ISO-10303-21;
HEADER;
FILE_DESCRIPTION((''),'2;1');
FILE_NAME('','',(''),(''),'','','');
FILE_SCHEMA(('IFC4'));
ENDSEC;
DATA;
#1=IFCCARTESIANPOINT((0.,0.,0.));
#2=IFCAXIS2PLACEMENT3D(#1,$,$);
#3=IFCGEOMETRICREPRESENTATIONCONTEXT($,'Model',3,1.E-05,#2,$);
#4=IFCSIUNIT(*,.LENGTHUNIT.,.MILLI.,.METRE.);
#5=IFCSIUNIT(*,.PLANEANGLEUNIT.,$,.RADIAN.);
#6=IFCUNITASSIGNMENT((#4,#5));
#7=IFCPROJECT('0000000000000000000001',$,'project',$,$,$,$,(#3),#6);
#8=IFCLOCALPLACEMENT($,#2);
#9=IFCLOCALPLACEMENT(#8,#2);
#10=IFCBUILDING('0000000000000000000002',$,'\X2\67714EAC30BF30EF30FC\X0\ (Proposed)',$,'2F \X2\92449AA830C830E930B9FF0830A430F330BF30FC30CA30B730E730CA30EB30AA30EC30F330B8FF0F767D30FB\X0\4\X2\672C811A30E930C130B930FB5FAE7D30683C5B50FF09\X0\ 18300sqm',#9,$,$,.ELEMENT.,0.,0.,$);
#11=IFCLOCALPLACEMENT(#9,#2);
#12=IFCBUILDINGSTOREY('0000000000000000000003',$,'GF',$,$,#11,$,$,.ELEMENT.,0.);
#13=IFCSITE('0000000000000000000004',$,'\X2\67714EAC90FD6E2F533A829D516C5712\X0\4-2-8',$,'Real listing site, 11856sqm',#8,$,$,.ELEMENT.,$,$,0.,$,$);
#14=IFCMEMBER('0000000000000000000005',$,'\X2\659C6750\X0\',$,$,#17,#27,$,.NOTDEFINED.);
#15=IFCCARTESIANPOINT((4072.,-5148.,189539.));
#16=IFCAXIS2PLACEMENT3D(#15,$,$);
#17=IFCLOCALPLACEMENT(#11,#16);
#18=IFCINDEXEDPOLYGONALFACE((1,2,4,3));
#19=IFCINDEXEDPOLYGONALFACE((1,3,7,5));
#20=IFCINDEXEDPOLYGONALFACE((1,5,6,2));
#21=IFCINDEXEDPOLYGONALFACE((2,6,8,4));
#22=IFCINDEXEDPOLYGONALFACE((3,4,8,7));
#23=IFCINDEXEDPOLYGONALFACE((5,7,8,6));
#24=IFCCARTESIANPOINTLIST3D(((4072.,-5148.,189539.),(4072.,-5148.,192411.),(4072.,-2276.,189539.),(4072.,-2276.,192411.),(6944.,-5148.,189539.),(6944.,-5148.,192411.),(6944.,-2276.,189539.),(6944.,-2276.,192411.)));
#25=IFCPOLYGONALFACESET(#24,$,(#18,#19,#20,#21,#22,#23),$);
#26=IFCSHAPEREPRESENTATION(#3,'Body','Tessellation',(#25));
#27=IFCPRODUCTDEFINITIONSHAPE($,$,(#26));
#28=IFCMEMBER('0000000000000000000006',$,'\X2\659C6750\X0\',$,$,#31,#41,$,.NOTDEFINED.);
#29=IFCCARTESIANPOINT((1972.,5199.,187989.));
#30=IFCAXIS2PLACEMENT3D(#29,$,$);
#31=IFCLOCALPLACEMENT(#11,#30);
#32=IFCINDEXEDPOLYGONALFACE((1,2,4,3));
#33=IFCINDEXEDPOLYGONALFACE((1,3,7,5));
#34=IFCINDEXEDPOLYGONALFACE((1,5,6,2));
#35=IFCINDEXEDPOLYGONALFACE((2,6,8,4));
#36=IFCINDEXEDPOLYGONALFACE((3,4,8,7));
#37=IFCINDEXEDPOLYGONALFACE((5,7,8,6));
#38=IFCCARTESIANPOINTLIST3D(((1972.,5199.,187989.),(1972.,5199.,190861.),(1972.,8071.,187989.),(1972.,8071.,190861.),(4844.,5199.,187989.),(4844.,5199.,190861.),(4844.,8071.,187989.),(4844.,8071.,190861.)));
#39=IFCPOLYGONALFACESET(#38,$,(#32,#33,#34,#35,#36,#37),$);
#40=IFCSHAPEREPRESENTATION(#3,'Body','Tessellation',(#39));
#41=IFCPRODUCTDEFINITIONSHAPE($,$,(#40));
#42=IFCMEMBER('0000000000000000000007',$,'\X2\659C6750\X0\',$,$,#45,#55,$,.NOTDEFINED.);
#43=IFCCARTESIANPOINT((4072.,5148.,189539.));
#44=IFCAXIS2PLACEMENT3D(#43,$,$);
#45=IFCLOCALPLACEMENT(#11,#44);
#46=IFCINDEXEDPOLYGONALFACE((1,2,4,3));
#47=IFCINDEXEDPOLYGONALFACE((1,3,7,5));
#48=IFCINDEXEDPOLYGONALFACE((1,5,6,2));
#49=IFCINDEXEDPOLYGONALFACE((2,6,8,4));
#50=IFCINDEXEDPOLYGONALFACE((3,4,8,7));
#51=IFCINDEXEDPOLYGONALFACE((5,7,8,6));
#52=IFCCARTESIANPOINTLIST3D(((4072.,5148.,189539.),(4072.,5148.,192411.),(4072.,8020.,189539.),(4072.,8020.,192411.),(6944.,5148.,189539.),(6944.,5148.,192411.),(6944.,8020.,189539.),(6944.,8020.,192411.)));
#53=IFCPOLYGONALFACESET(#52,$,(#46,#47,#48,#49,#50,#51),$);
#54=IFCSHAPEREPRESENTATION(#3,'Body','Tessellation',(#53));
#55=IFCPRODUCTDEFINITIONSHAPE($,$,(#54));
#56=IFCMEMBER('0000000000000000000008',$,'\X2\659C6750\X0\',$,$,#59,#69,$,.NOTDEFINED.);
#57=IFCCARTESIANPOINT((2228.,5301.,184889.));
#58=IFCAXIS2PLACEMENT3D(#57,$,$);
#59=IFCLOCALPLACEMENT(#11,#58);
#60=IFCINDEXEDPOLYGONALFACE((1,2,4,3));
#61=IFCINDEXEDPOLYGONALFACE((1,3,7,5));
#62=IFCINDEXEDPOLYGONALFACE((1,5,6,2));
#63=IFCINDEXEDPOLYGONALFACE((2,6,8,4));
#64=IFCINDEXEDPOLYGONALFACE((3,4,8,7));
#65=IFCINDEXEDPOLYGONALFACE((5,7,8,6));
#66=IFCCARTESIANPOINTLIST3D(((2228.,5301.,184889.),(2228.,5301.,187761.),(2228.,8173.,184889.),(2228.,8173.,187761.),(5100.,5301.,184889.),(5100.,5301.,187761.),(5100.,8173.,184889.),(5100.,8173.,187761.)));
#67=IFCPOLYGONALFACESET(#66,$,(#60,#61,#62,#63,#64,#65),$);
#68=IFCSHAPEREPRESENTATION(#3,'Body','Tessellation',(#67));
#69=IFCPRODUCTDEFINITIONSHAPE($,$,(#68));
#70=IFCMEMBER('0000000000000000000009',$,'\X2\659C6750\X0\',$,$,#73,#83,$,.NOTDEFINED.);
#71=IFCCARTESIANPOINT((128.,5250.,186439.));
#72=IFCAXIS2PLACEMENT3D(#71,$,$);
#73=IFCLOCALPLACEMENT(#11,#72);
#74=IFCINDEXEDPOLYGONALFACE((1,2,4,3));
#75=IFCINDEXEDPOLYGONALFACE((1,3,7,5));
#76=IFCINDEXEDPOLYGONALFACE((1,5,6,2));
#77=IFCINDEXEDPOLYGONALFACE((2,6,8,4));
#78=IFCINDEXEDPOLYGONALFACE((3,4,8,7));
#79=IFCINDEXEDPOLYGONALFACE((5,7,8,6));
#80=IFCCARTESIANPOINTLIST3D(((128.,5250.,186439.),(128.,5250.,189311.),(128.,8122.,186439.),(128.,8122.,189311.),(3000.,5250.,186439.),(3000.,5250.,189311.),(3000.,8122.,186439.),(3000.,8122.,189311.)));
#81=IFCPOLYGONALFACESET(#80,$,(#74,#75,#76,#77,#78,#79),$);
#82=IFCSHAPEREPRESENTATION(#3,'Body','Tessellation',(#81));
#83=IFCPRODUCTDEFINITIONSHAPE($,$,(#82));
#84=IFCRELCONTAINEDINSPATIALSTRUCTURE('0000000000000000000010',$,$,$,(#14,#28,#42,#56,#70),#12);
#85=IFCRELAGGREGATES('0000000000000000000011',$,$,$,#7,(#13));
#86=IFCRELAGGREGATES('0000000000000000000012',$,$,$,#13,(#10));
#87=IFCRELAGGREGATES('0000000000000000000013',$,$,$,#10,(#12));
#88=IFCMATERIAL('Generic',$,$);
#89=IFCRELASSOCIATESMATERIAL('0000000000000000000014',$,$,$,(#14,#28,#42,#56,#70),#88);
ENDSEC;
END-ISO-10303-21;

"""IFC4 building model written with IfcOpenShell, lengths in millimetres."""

from ifc_helpers import new_model, si_unit, frame, frame_2d, origin, place, context, project, spatial, rectangle, extrude, material, element, save


model = new_model("IFC4")

# Units and contexts
model_context = context("Model", 3, precision=1e-05, world=origin())
ifc_project = project(units=[si_unit("LENGTHUNIT", "METRE", prefix="MILLI"), si_unit("PLANEANGLEUNIT", "RADIAN")], contexts=[model_context])

# Site, building, storey
site_placement = place(None, origin())
site = spatial("IfcSite", under=ifc_project, at=site_placement, Name="東京都港区芝公園4-2-8", ObjectType="Real listing site, 11856sqm", CompositionType="ELEMENT", RefElevation=0.0)
building_placement = place(site_placement, origin())
building = spatial("IfcBuilding", under=site, at=building_placement, Name="東京タワー (Proposed)", ObjectType="2F 鉄骨トラス（インターナショナルオレンジ／白・4本脚ラチス・微細格子） 18300sqm", CompositionType="ELEMENT", ElevationOfRefHeight=0.0, ElevationOfTerrain=0.0)
storey_placement = place(building_placement, origin())
storey = spatial("IfcBuildingStorey", under=building, at=storey_placement, Name="GF", CompositionType="ELEMENT", Elevation=0.0)

# Shared definitions
ifc_material = material(Name="Generic")

# Members
member_1_placement = place(storey_placement, frame((4072.0, -5148.0, 189539.0)))
element("IfcMember", 1, at=member_1_placement, inside=storey, material=ifc_material, Name="斜材", PredefinedType="NOTDEFINED", context=model_context, shape_type="SweptSolid", body=[
    extrude(rectangle(XDim=2872.0, YDim=2872.0, at=frame_2d((1436.0, 1436.0))), frame((4072.0, -5148.0, 189539.0)), (0.0, 0.0, 1.0), 2872.0),
])
member_2_placement = place(storey_placement, frame((1972.0, 5199.0, 187989.0)))
element("IfcMember", 2, at=member_2_placement, inside=storey, material=ifc_material, Name="斜材", PredefinedType="NOTDEFINED", context=model_context, shape_type="SweptSolid", body=[
    extrude(rectangle(XDim=2872.0, YDim=2872.0, at=frame_2d((1436.0, 1436.0))), frame((1972.0, 5199.0, 187989.0)), (0.0, 0.0, 1.0), 2872.0),
])
member_3_placement = place(storey_placement, frame((4072.0, 5148.0, 189539.0)))
element("IfcMember", 3, at=member_3_placement, inside=storey, material=ifc_material, Name="斜材", PredefinedType="NOTDEFINED", context=model_context, shape_type="SweptSolid", body=[
    extrude(rectangle(XDim=2872.0, YDim=2872.0, at=frame_2d((1436.0, 1436.0))), frame((4072.0, 5148.0, 189539.0)), (0.0, 0.0, 1.0), 2872.0),
])
member_4_placement = place(storey_placement, frame((2228.0, 5301.0, 184889.0)))
element("IfcMember", 4, at=member_4_placement, inside=storey, material=ifc_material, Name="斜材", PredefinedType="NOTDEFINED", context=model_context, shape_type="SweptSolid", body=[
    extrude(rectangle(XDim=2872.0, YDim=2872.0, at=frame_2d((1436.0, 1436.0))), frame((2228.0, 5301.0, 184889.0)), (0.0, 0.0, 1.0), 2872.0),
])
member_5_placement = place(storey_placement, frame((128.0, 5250.0, 186439.0)))
element("IfcMember", 5, at=member_5_placement, inside=storey, material=ifc_material, Name="斜材", PredefinedType="NOTDEFINED", context=model_context, shape_type="SweptSolid", body=[
    extrude(rectangle(XDim=2872.0, YDim=2872.0, at=frame_2d((1436.0, 1436.0))), frame((128.0, 5250.0, 186439.0)), (0.0, 0.0, 1.0), 2872.0),
])

save(model, "model.ifc")
